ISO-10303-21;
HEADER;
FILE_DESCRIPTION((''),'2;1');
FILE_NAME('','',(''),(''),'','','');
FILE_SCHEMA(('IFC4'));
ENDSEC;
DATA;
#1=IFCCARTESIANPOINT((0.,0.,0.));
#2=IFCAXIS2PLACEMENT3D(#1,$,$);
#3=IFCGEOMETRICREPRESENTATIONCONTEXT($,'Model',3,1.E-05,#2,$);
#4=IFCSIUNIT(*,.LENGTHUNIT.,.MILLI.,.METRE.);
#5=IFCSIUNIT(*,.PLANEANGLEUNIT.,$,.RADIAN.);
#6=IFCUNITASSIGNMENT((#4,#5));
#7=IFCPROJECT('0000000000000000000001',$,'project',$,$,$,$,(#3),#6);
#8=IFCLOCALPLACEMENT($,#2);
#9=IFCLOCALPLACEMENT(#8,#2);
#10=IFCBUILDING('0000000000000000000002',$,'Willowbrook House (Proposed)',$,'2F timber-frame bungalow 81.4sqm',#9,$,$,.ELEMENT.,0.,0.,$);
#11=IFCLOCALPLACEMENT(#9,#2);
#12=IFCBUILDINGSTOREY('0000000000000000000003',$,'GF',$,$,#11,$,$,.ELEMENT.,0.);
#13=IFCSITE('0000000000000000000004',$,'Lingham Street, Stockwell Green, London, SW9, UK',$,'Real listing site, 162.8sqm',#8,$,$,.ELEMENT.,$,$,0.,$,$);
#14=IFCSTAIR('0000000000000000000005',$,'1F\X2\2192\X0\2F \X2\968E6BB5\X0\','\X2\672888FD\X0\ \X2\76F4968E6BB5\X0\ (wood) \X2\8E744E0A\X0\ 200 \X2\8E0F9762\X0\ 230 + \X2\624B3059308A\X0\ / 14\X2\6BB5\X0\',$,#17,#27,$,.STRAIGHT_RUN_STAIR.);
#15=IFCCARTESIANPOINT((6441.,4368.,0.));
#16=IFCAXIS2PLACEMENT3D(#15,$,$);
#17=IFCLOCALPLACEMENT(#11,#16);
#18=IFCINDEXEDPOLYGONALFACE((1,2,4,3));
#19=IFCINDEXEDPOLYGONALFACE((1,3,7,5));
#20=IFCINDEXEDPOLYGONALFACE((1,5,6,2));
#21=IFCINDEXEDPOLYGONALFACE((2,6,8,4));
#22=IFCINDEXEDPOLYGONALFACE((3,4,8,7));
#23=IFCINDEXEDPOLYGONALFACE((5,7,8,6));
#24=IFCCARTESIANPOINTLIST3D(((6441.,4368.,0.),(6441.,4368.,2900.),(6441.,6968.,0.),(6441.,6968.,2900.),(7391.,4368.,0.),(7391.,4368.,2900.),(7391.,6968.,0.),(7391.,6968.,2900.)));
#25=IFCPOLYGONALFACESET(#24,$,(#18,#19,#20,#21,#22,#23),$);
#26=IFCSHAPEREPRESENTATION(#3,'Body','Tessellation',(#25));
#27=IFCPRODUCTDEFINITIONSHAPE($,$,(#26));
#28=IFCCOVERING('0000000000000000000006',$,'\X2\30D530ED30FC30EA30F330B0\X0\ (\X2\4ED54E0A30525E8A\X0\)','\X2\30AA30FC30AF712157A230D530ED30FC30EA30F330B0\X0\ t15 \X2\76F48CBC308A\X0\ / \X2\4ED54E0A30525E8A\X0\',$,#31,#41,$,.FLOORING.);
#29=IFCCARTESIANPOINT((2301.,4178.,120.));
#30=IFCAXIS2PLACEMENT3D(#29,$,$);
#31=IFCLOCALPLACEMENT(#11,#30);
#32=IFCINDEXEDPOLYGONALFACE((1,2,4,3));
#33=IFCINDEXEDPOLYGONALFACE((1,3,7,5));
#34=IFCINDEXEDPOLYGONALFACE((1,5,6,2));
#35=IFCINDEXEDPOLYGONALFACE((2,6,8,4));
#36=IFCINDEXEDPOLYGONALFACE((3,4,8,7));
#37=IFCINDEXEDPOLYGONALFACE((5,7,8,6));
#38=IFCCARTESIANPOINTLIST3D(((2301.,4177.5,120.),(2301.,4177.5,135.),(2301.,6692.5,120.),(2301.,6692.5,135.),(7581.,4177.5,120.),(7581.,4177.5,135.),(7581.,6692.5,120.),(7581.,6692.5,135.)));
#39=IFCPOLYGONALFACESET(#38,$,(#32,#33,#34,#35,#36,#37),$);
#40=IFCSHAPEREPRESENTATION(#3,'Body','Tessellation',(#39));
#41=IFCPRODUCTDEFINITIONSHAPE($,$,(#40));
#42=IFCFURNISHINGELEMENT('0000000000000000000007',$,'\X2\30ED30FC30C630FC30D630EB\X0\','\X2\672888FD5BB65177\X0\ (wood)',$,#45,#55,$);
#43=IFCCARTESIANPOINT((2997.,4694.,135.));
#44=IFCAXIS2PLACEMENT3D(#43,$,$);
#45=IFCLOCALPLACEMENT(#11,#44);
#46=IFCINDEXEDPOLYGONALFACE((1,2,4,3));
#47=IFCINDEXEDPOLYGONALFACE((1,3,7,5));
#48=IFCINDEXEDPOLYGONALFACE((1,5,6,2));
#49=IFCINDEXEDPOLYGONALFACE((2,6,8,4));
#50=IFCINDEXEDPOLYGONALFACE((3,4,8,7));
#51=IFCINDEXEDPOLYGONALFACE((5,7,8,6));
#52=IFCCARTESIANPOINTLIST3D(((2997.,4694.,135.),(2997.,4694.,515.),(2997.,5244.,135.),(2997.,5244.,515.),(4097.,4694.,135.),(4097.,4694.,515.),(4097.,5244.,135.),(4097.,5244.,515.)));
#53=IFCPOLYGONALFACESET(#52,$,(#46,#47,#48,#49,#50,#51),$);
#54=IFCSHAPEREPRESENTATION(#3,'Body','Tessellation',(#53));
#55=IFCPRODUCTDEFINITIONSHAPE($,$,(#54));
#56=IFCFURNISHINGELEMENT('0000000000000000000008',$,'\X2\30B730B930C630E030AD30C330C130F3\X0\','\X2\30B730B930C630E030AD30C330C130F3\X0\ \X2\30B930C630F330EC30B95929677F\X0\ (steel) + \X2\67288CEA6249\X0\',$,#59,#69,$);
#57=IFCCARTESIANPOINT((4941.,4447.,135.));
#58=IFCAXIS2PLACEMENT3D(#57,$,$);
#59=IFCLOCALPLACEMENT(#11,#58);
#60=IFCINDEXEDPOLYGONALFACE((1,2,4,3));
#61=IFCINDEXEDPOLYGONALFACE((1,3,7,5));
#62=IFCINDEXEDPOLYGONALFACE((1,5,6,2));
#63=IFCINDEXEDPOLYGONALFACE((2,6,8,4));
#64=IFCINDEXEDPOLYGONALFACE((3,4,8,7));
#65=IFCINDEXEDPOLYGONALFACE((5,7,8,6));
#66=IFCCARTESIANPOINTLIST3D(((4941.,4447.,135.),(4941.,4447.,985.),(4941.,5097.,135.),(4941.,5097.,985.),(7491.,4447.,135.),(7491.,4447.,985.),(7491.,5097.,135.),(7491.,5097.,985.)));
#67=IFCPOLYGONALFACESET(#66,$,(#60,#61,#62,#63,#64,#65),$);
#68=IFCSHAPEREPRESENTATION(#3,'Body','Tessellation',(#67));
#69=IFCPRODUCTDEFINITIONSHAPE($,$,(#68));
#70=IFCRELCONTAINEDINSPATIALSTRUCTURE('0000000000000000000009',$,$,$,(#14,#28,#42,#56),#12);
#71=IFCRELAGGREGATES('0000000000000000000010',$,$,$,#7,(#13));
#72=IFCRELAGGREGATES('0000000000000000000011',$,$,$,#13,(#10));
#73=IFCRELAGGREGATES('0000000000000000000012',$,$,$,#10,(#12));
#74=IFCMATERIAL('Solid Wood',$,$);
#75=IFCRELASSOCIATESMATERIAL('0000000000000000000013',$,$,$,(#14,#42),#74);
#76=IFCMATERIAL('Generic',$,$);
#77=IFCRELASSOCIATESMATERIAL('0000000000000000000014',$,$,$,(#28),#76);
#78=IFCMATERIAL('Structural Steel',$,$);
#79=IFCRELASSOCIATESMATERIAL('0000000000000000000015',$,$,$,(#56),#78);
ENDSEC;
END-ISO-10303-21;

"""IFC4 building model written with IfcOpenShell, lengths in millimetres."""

from ifc_helpers import new_model, si_unit, frame, frame_2d, origin, place, context, project, spatial, rectangle, extrude, material, element, save


model = new_model("IFC4")

# Units and contexts
model_context = context("Model", 3, precision=1e-05, world=origin())
ifc_project = project(units=[si_unit("LENGTHUNIT", "METRE", prefix="MILLI"), si_unit("PLANEANGLEUNIT", "RADIAN")], contexts=[model_context])

# Site, building, storey
site_placement = place(None, origin())
site = spatial("IfcSite", under=ifc_project, at=site_placement, Name="Lingham Street, Stockwell Green, London, SW9, UK", ObjectType="Real listing site, 162.8sqm", CompositionType="ELEMENT", RefElevation=0.0)
building_placement = place(site_placement, origin())
building = spatial("IfcBuilding", under=site, at=building_placement, Name="Willowbrook House (Proposed)", ObjectType="2F timber-frame bungalow 81.4sqm", CompositionType="ELEMENT", ElevationOfRefHeight=0.0, ElevationOfTerrain=0.0)
storey_placement = place(building_placement, origin())
storey = spatial("IfcBuildingStorey", under=building, at=storey_placement, Name="GF", CompositionType="ELEMENT", Elevation=0.0)

# Shared definitions
ifc_material_1 = material(Name="Solid Wood")

# Stair
stair_placement = place(storey_placement, frame((6441.0, 4368.0, 0.0)))
element("IfcStair", 1, at=stair_placement, inside=storey, material=ifc_material_1, Name="1F→2F 階段", Description="木製 直階段 (wood) 蹴上 200 踏面 230 + 手すり / 14段", PredefinedType="STRAIGHT_RUN_STAIR", context=model_context, shape_type="SweptSolid", body=[
    extrude(rectangle(XDim=950.0, YDim=2600.0, at=frame_2d((475.0, 1300.0))), frame((6441.0, 4368.0, 0.0)), (0.0, 0.0, 1.0), 2900.0),
])

# Covering
ifc_material_2 = material(Name="Generic")
covering_placement = place(storey_placement, frame((2301.0, 4178.0, 120.0)))
element("IfcCovering", 2, at=covering_placement, inside=storey, material=ifc_material_2, Name="フローリング (仕上げ床)", Description="オーク無垢フローリング t15 直貼り / 仕上げ床", PredefinedType="FLOORING", context=model_context, shape_type="SweptSolid", body=[
    extrude(rectangle(XDim=5280.0, YDim=2515.0, at=frame_2d((2640.0, 1257.0))), frame((2301.0, 4178.0, 120.0)), (0.0, 0.0, 1.0), 15.0),
])

# Furnishing elements
furnishing_1_placement = place(storey_placement, frame((2997.0, 4694.0, 135.0)))
element("IfcFurnishingElement", 3, at=furnishing_1_placement, inside=storey, material=ifc_material_1, Name="ローテーブル", Description="木製家具 (wood)", context=model_context, shape_type="SweptSolid", body=[
    extrude(rectangle(XDim=1100.0, YDim=550.0, at=frame_2d((550.0, 275.0))), frame((2997.0, 4694.0, 135.0)), (0.0, 0.0, 1.0), 380.0),
])
ifc_material_3 = material(Name="Structural Steel")
furnishing_2_placement = place(storey_placement, frame((4941.0, 4447.0, 135.0)))
element("IfcFurnishingElement", 4, at=furnishing_2_placement, inside=storey, material=ifc_material_3, Name="システムキッチン", Description="システムキッチン ステンレス天板 (steel) + 木質扉", context=model_context, shape_type="SweptSolid", body=[
    extrude(rectangle(XDim=2550.0, YDim=650.0, at=frame_2d((1275.0, 325.0))), frame((4941.0, 4447.0, 135.0)), (0.0, 0.0, 1.0), 850.0),
])

save(model, "model.ifc")
